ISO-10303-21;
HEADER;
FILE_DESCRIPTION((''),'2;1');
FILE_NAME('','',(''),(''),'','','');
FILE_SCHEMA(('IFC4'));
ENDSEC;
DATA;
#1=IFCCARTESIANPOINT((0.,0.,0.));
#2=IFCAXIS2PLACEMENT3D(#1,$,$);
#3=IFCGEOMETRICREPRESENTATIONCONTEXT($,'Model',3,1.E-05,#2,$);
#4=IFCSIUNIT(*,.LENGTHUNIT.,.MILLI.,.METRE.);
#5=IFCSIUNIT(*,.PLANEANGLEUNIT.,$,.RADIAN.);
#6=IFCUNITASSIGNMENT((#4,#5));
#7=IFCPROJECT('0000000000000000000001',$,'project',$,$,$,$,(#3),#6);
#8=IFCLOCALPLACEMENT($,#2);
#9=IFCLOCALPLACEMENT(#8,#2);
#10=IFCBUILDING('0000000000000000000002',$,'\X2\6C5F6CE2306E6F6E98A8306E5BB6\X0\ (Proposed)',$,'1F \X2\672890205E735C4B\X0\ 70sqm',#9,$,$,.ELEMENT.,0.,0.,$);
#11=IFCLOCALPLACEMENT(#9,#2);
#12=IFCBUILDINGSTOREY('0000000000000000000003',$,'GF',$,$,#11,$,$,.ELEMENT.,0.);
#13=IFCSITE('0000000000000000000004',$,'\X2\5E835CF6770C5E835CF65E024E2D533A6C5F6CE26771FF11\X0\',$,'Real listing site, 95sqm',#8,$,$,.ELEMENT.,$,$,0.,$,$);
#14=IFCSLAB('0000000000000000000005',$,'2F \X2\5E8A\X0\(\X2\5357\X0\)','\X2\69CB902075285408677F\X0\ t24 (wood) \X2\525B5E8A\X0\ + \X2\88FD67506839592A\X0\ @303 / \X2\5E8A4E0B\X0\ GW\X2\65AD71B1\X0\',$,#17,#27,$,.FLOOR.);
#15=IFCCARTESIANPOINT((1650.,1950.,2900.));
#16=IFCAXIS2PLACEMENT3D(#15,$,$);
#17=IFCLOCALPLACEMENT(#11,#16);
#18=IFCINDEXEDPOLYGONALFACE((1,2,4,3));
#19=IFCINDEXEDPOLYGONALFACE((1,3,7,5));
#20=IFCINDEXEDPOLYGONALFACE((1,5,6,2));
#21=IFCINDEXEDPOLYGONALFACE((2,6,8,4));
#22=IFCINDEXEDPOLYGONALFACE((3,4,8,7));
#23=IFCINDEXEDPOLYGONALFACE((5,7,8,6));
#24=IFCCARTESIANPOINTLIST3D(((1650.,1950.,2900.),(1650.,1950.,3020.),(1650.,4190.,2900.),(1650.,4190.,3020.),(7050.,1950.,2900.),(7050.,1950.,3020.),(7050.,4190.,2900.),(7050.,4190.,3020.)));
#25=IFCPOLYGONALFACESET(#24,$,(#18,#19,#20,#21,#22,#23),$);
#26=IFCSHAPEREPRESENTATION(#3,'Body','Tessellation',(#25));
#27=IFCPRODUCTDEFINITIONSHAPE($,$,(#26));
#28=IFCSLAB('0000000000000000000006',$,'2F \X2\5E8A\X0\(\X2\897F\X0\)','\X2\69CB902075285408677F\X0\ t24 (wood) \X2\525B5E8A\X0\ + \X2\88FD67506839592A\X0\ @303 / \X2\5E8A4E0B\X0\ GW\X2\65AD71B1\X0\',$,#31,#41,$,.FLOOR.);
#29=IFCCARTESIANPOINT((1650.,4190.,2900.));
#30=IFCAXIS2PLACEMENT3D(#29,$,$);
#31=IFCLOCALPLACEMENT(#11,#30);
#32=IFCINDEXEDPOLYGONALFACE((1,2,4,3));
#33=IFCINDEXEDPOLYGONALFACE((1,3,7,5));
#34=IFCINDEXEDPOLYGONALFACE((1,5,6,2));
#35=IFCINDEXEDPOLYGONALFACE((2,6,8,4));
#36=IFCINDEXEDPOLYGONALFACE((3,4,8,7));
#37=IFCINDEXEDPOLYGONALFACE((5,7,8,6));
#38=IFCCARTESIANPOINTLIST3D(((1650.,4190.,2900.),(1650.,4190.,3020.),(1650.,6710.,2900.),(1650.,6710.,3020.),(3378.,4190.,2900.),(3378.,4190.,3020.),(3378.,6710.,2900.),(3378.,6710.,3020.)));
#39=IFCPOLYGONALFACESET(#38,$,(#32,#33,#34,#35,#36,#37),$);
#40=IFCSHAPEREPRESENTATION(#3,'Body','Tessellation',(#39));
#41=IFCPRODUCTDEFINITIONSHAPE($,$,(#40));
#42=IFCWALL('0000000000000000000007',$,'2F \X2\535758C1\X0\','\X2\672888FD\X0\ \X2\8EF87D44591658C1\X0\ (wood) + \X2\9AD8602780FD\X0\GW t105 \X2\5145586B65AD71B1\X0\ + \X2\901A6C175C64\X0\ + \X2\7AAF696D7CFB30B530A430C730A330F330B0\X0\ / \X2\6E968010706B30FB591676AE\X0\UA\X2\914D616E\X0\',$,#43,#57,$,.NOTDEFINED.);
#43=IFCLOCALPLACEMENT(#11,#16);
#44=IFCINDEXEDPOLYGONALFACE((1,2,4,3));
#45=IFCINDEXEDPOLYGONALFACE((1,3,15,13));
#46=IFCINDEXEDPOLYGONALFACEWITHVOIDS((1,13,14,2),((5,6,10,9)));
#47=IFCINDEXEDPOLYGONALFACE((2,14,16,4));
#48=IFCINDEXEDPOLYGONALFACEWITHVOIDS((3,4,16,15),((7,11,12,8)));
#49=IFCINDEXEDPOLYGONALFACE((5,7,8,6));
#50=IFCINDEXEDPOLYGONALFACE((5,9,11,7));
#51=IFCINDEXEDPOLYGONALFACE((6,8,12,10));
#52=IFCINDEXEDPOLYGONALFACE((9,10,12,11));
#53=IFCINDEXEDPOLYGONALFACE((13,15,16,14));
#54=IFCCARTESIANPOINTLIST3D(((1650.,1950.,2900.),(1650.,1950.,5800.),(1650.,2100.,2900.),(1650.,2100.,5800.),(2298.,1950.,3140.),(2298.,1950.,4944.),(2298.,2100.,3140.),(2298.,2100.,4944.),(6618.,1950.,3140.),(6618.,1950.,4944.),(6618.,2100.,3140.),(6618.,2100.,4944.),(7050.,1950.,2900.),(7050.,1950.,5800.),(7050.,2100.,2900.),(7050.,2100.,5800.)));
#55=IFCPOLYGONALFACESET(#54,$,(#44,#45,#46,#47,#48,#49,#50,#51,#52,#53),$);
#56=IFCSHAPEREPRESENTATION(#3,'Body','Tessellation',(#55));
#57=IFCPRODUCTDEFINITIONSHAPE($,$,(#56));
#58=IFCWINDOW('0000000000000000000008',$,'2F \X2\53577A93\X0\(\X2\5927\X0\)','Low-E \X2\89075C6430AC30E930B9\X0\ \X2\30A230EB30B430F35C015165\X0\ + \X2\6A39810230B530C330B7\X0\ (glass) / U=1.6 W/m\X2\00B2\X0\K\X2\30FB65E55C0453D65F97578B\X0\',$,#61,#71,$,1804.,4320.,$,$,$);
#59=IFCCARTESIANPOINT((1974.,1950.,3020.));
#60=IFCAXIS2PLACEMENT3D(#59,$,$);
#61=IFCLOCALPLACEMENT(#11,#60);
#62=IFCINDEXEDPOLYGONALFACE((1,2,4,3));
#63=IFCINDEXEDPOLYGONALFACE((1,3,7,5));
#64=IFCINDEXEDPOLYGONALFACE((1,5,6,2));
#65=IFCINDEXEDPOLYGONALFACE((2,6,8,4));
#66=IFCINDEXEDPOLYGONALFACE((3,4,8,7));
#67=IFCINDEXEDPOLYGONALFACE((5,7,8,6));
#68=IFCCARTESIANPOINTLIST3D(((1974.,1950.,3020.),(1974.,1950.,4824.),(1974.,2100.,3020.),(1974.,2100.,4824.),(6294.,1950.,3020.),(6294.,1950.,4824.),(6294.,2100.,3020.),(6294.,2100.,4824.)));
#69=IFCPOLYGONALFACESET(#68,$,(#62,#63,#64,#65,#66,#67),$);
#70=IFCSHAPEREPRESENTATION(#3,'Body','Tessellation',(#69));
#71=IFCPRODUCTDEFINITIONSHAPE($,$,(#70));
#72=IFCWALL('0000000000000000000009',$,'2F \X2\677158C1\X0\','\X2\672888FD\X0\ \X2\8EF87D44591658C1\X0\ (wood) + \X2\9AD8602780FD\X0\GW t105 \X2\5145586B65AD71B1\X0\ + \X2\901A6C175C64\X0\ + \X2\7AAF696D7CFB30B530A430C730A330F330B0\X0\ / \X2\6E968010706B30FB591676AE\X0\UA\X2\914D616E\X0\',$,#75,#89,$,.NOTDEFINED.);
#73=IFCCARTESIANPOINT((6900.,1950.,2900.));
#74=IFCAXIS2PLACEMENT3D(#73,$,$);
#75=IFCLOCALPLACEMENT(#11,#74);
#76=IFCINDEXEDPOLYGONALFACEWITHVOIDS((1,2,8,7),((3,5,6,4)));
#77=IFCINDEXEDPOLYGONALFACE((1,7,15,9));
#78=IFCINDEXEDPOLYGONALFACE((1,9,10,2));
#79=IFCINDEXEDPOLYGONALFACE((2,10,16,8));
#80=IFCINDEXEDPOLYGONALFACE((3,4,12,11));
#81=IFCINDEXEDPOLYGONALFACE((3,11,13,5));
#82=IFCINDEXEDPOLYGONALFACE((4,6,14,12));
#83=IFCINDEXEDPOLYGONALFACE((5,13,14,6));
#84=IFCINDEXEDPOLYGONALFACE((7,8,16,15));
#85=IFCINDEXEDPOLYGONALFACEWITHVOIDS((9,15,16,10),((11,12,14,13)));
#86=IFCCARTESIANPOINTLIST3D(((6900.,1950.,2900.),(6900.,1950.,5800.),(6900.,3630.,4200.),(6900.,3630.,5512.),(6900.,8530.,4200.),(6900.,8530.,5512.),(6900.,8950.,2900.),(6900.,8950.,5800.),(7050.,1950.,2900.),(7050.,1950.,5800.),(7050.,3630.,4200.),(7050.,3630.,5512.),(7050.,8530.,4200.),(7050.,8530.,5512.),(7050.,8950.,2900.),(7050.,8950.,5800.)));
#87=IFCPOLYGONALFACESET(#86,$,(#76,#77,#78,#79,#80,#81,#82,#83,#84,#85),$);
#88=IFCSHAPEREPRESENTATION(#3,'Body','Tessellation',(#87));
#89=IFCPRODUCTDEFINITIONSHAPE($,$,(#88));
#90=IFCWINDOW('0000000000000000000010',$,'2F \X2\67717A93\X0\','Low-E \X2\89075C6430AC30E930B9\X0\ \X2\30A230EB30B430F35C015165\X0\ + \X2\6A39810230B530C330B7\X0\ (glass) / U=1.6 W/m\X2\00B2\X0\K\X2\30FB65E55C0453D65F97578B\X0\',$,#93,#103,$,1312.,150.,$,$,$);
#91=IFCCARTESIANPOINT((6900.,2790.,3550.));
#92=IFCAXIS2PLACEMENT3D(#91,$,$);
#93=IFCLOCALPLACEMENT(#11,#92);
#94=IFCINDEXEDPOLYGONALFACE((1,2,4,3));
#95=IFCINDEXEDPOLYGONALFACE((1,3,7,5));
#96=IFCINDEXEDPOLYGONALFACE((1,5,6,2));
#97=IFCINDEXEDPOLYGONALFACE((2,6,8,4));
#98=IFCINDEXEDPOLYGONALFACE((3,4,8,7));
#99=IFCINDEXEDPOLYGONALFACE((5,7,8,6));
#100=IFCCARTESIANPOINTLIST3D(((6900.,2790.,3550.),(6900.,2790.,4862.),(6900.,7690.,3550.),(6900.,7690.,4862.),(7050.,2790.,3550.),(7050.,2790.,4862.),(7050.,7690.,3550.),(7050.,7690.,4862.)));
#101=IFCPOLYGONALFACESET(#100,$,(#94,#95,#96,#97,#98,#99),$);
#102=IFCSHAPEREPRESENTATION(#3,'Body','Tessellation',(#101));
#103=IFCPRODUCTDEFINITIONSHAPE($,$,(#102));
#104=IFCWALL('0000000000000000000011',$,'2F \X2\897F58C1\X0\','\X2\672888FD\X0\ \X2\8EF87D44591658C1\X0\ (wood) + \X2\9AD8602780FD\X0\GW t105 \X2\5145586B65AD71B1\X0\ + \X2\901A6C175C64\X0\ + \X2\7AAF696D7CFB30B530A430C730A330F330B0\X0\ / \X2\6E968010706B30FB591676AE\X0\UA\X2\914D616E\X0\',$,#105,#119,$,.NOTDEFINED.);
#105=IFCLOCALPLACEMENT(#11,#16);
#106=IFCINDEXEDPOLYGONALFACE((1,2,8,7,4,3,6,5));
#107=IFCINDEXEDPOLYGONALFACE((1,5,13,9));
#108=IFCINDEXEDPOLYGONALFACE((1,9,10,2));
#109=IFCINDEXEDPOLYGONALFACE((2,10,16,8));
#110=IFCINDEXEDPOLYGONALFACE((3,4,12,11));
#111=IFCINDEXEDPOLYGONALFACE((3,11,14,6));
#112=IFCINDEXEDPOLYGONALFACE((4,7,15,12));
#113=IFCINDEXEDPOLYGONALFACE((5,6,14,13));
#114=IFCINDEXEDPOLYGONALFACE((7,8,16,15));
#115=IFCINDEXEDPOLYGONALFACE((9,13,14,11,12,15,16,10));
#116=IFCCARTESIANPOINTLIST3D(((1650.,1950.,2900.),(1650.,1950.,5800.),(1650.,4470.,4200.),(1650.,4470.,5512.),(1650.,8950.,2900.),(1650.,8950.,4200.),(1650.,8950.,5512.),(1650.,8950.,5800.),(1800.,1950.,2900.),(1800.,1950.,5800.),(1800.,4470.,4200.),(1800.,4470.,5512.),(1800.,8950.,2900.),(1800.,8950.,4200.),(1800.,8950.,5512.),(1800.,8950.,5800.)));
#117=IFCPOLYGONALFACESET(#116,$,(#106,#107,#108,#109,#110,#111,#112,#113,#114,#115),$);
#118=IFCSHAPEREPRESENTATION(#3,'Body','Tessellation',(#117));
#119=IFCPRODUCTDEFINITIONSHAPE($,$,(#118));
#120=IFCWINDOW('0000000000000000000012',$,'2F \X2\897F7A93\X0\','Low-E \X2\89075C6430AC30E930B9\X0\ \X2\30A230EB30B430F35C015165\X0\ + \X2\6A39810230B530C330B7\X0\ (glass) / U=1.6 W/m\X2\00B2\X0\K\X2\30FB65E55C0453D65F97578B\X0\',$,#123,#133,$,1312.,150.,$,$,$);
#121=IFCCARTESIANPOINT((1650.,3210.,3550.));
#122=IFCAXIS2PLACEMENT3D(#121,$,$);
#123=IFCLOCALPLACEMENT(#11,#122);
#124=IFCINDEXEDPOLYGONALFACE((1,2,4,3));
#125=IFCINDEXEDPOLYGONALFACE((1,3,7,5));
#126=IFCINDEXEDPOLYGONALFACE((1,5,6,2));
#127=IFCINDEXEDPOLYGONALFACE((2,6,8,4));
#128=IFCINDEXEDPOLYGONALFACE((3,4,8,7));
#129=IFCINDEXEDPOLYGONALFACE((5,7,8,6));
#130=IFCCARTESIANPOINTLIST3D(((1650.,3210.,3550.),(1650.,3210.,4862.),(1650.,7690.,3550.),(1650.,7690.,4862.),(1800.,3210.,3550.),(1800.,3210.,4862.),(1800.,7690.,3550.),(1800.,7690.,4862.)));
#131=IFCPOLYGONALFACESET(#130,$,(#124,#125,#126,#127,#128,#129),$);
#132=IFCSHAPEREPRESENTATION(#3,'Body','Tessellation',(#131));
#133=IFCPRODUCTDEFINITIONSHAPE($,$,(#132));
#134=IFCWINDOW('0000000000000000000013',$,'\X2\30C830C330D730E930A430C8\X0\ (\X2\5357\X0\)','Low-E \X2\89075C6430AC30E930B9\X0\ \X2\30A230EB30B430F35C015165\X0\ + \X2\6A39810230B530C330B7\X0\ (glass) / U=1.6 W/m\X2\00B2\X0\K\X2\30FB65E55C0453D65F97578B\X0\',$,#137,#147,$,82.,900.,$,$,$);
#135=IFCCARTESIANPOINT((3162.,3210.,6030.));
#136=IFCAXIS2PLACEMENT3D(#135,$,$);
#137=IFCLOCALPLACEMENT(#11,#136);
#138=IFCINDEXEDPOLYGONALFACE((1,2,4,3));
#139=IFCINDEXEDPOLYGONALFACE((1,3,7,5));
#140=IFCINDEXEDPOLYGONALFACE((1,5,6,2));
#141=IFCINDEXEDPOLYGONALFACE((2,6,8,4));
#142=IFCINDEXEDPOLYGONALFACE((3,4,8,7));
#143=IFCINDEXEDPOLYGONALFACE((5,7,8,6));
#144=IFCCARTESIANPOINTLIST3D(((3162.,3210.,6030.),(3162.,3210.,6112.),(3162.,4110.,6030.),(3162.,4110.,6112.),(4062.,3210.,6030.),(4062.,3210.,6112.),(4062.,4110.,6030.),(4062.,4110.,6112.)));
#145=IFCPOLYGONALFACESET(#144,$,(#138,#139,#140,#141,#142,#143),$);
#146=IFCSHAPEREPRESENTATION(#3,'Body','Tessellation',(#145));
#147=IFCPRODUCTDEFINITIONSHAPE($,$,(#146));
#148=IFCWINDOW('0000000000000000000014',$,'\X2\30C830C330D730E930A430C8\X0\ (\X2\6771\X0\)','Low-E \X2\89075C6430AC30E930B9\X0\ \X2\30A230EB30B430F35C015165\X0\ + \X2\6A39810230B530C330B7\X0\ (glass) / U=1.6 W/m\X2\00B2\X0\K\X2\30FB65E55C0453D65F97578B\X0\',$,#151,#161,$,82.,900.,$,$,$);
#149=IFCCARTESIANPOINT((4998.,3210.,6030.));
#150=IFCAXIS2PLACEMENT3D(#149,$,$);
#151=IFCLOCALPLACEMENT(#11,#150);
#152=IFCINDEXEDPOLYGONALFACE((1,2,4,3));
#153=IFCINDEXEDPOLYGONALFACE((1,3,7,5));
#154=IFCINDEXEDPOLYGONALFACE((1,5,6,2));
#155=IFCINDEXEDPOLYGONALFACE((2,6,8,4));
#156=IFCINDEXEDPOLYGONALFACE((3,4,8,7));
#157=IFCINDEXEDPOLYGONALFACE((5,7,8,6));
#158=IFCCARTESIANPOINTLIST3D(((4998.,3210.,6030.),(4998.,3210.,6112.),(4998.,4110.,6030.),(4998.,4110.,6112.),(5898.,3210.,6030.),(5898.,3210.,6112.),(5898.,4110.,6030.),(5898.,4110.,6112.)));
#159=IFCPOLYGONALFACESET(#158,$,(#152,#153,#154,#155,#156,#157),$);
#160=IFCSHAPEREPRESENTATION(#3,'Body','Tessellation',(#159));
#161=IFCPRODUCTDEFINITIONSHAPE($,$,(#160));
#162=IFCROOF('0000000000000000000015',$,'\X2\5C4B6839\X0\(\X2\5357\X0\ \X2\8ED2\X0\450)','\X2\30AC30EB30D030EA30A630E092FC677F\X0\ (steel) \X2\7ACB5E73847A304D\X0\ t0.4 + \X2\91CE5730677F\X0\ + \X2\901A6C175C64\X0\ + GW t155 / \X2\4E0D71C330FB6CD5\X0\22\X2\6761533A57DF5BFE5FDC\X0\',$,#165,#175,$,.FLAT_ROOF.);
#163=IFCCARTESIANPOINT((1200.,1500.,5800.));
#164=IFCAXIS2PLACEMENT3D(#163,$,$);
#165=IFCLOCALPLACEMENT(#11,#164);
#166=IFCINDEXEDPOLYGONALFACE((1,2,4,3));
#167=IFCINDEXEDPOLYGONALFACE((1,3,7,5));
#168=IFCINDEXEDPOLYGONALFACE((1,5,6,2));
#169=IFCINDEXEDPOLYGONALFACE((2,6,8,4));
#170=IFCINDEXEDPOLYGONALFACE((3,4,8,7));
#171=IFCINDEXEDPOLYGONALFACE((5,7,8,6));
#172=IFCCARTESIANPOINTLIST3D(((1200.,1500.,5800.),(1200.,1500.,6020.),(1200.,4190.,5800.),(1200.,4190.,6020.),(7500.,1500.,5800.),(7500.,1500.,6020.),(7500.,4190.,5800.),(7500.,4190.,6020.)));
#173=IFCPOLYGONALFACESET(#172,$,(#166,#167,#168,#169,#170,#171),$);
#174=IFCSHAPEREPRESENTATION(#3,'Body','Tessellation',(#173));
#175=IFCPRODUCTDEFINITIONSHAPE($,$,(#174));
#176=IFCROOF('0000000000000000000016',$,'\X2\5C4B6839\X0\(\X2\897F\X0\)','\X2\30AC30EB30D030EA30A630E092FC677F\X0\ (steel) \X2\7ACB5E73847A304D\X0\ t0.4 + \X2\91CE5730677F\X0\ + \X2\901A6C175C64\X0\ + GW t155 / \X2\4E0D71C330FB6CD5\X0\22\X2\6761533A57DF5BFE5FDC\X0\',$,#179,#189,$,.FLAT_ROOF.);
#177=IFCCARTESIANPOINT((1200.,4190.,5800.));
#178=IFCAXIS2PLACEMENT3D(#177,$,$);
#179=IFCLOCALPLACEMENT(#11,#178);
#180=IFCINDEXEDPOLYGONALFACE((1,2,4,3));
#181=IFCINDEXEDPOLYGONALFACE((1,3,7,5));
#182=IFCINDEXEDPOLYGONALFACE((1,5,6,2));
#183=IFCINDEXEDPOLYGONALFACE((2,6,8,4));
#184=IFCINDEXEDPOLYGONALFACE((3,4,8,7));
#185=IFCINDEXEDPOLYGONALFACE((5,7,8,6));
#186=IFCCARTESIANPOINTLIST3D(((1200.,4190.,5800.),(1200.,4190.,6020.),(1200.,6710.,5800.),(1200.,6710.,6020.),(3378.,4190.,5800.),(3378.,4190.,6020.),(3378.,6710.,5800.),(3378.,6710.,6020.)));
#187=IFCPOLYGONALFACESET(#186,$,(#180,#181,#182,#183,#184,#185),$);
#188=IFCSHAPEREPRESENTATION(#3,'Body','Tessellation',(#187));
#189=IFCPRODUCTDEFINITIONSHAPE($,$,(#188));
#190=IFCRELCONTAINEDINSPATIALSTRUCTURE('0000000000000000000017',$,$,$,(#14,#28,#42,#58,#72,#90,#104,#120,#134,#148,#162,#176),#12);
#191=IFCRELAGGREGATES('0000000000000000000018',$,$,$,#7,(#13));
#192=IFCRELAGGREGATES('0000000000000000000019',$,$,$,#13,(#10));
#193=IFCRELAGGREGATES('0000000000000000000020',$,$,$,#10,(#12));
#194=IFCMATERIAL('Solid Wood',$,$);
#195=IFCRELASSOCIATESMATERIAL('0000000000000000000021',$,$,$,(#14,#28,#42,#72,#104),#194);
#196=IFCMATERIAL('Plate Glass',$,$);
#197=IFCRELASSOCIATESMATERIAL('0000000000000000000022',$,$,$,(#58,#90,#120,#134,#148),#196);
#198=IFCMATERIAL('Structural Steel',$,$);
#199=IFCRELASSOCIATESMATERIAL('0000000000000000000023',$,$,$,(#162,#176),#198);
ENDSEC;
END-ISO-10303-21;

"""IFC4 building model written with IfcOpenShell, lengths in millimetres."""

from ifc_helpers import new_model, si_unit, frame, frame_2d, origin, place, context, project, spatial, rectangle, extrude, material, element, fill, save


model = new_model("IFC4")

# Units and contexts
model_context = context("Model", 3, precision=1e-05, world=origin())
ifc_project = project(units=[si_unit("LENGTHUNIT", "METRE", prefix="MILLI"), si_unit("PLANEANGLEUNIT", "RADIAN")], contexts=[model_context])

# Site, building, storey
site_placement = place(None, origin())
site = spatial("IfcSite", under=ifc_project, at=site_placement, Name="広島県広島市中区江波東１", ObjectType="Real listing site, 95sqm", CompositionType="ELEMENT", RefElevation=0.0)
building_placement = place(site_placement, origin())
building = spatial("IfcBuilding", under=site, at=building_placement, Name="江波の潮風の家 (Proposed)", ObjectType="1F 木造平屋 70sqm", CompositionType="ELEMENT", ElevationOfRefHeight=0.0, ElevationOfTerrain=0.0)
storey_placement = place(building_placement, origin())
storey = spatial("IfcBuildingStorey", under=building, at=storey_placement, Name="GF", CompositionType="ELEMENT", Elevation=0.0)

# Slabs
ifc_material_1 = material(Name="Solid Wood")
slab_1_placement = place(storey_placement, frame((1650.0, 1950.0, 2900.0)))
element("IfcSlab", 1, at=slab_1_placement, inside=storey, material=ifc_material_1, Name="2F 床(南)", Description="構造用合板 t24 (wood) 剛床 + 製材根太 @303 / 床下 GW断熱", PredefinedType="FLOOR", context=model_context, shape_type="SweptSolid", body=[
    extrude(rectangle(XDim=5400.0, YDim=2240.0, at=frame_2d((2700.0, 1120.0))), frame((1650.0, 1950.0, 2900.0)), (0.0, 0.0, 1.0), 120.0),
])
slab_2_placement = place(storey_placement, frame((1650.0, 4190.0, 2900.0)))
element("IfcSlab", 2, at=slab_2_placement, inside=storey, material=ifc_material_1, Name="2F 床(西)", Description="構造用合板 t24 (wood) 剛床 + 製材根太 @303 / 床下 GW断熱", PredefinedType="FLOOR", context=model_context, shape_type="SweptSolid", body=[
    extrude(rectangle(XDim=1728.0, YDim=2520.0, at=frame_2d((864.0, 1260.0))), frame((1650.0, 4190.0, 2900.0)), (0.0, 0.0, 1.0), 120.0),
])

# Walls, openings, windows
wall_1_placement = place(storey_placement, frame((1650.0, 1950.0, 2900.0)))
wall_1 = element("IfcWall", 3, at=wall_1_placement, inside=storey, material=ifc_material_1, Name="2F 南壁", Description="木製 軸組外壁 (wood) + 高性能GW t105 充填断熱 + 通気層 + 窯業系サイディング / 準耐火・外皮UA配慮", PredefinedType="NOTDEFINED", context=model_context, shape_type="SweptSolid", body=[
    extrude(rectangle(XDim=5400.0, YDim=150.0, at=frame_2d((2700.0, 75.0))), frame((1650.0, 1950.0, 2900.0)), (0.0, 0.0, 1.0), 2900.0),
])
opening_1_placement = place(storey_placement, frame((1974.0, 1950.0, 3020.0)))
opening_1 = element("IfcOpeningElement", 4, at=opening_1_placement, cuts=wall_1, PredefinedType="NOTDEFINED", context=model_context, shape_type="SweptSolid", body=[
    extrude(rectangle(XDim=4320.0, YDim=150.0, at=frame_2d((2160.0, 75.0))), frame((1974.0, 1950.0, 3020.0)), (0.0, 0.0, 1.0), 1804.0),
])
ifc_material_2 = material(Name="Plate Glass")
window_1_placement = place(storey_placement, frame((1974.0, 1950.0, 3020.0)))
window_1 = element("IfcWindow", 5, at=window_1_placement, inside=storey, material=ifc_material_2, Name="2F 南窓(大)", Description="Low-E 複層ガラス アルゴン封入 + 樹脂サッシ (glass) / U=1.6 W/m²K・日射取得型", OverallHeight=1804.0, OverallWidth=4320.0, context=model_context, shape_type="SweptSolid", body=[
    extrude(rectangle(XDim=4320.0, YDim=150.0, at=frame_2d((2160.0, 75.0))), frame((1974.0, 1950.0, 3020.0)), (0.0, 0.0, 1.0), 1804.0),
])
fill(opening_1, window_1)
wall_2_placement = place(storey_placement, frame((6900.0, 1950.0, 2900.0)))
wall_2 = element("IfcWall", 6, at=wall_2_placement, inside=storey, material=ifc_material_1, Name="2F 東壁", Description="木製 軸組外壁 (wood) + 高性能GW t105 充填断熱 + 通気層 + 窯業系サイディング / 準耐火・外皮UA配慮", PredefinedType="NOTDEFINED", context=model_context, shape_type="SweptSolid", body=[
    extrude(rectangle(XDim=150.0, YDim=7000.0, at=frame_2d((75.0, 3500.0))), frame((6900.0, 1950.0, 2900.0)), (0.0, 0.0, 1.0), 2900.0),
])
opening_2_placement = place(storey_placement, frame((6900.0, 2790.0, 3550.0)))
opening_2 = element("IfcOpeningElement", 7, at=opening_2_placement, cuts=wall_2, PredefinedType="NOTDEFINED", context=model_context, shape_type="SweptSolid", body=[
    extrude(rectangle(XDim=150.0, YDim=4900.0, at=frame_2d((75.0, 2450.0))), frame((6900.0, 2790.0, 3550.0)), (0.0, 0.0, 1.0), 1312.0),
])
window_2_placement = place(storey_placement, frame((6900.0, 2790.0, 3550.0)))
window_2 = element("IfcWindow", 8, at=window_2_placement, inside=storey, material=ifc_material_2, Name="2F 東窓", Description="Low-E 複層ガラス アルゴン封入 + 樹脂サッシ (glass) / U=1.6 W/m²K・日射取得型", OverallHeight=1312.0, OverallWidth=150.0, context=model_context, shape_type="SweptSolid", body=[
    extrude(rectangle(XDim=150.0, YDim=4900.0, at=frame_2d((75.0, 2450.0))), frame((6900.0, 2790.0, 3550.0)), (0.0, 0.0, 1.0), 1312.0),
])
fill(opening_2, window_2)
wall_3_placement = place(storey_placement, frame((1650.0, 1950.0, 2900.0)))
wall_3 = element("IfcWall", 9, at=wall_3_placement, inside=storey, material=ifc_material_1, Name="2F 西壁", Description="木製 軸組外壁 (wood) + 高性能GW t105 充填断熱 + 通気層 + 窯業系サイディング / 準耐火・外皮UA配慮", PredefinedType="NOTDEFINED", context=model_context, shape_type="SweptSolid", body=[
    extrude(rectangle(XDim=150.0, YDim=7000.0, at=frame_2d((75.0, 3500.0))), frame((1650.0, 1950.0, 2900.0)), (0.0, 0.0, 1.0), 2900.0),
])
opening_3_placement = place(storey_placement, frame((1650.0, 3210.0, 3550.0)))
opening_3 = element("IfcOpeningElement", 10, at=opening_3_placement, cuts=wall_3, PredefinedType="NOTDEFINED", context=model_context, shape_type="SweptSolid", body=[
    extrude(rectangle(XDim=150.0, YDim=4480.0, at=frame_2d((75.0, 2240.0))), frame((1650.0, 3210.0, 3550.0)), (0.0, 0.0, 1.0), 1312.0),
])
window_3_placement = place(storey_placement, frame((1650.0, 3210.0, 3550.0)))
window_3 = element("IfcWindow", 11, at=window_3_placement, inside=storey, material=ifc_material_2, Name="2F 西窓", Description="Low-E 複層ガラス アルゴン封入 + 樹脂サッシ (glass) / U=1.6 W/m²K・日射取得型", OverallHeight=1312.0, OverallWidth=150.0, context=model_context, shape_type="SweptSolid", body=[
    extrude(rectangle(XDim=150.0, YDim=4480.0, at=frame_2d((75.0, 2240.0))), frame((1650.0, 3210.0, 3550.0)), (0.0, 0.0, 1.0), 1312.0),
])
fill(opening_3, window_3)

# Windows
window_4_placement = place(storey_placement, frame((3162.0, 3210.0, 6030.0)))
element("IfcWindow", 12, at=window_4_placement, inside=storey, material=ifc_material_2, Name="トップライト (南)", Description="Low-E 複層ガラス アルゴン封入 + 樹脂サッシ (glass) / U=1.6 W/m²K・日射取得型", OverallHeight=82.0, OverallWidth=900.0, context=model_context, shape_type="SweptSolid", body=[
    extrude(rectangle(XDim=900.0, YDim=900.0, at=frame_2d((450.0, 450.0))), frame((3162.0, 3210.0, 6030.0)), (0.0, 0.0, 1.0), 82.0),
])
window_5_placement = place(storey_placement, frame((4998.0, 3210.0, 6030.0)))
element("IfcWindow", 13, at=window_5_placement, inside=storey, material=ifc_material_2, Name="トップライト (東)", Description="Low-E 複層ガラス アルゴン封入 + 樹脂サッシ (glass) / U=1.6 W/m²K・日射取得型", OverallHeight=82.0, OverallWidth=900.0, context=model_context, shape_type="SweptSolid", body=[
    extrude(rectangle(XDim=900.0, YDim=900.0, at=frame_2d((450.0, 450.0))), frame((4998.0, 3210.0, 6030.0)), (0.0, 0.0, 1.0), 82.0),
])

# Roofs
ifc_material_3 = material(Name="Structural Steel")
roof_1_placement = place(storey_placement, frame((1200.0, 1500.0, 5800.0)))
element("IfcRoof", 14, at=roof_1_placement, inside=storey, material=ifc_material_3, Name="屋根(南 軒450)", Description="ガルバリウム鋼板 (steel) 立平葺き t0.4 + 野地板 + 通気層 + GW t155 / 不燃・法22条区域対応", PredefinedType="FLAT_ROOF", context=model_context, shape_type="SweptSolid", body=[
    extrude(rectangle(XDim=6300.0, YDim=2690.0, at=frame_2d((3150.0, 1345.0))), frame((1200.0, 1500.0, 5800.0)), (0.0, 0.0, 1.0), 220.0),
])
roof_2_placement = place(storey_placement, frame((1200.0, 4190.0, 5800.0)))
element("IfcRoof", 15, at=roof_2_placement, inside=storey, material=ifc_material_3, Name="屋根(西)", Description="ガルバリウム鋼板 (steel) 立平葺き t0.4 + 野地板 + 通気層 + GW t155 / 不燃・法22条区域対応", PredefinedType="FLAT_ROOF", context=model_context, shape_type="SweptSolid", body=[
    extrude(rectangle(XDim=2178.0, YDim=2520.0, at=frame_2d((1089.0, 1260.0))), frame((1200.0, 4190.0, 5800.0)), (0.0, 0.0, 1.0), 220.0),
])

save(model, "model.ifc")
